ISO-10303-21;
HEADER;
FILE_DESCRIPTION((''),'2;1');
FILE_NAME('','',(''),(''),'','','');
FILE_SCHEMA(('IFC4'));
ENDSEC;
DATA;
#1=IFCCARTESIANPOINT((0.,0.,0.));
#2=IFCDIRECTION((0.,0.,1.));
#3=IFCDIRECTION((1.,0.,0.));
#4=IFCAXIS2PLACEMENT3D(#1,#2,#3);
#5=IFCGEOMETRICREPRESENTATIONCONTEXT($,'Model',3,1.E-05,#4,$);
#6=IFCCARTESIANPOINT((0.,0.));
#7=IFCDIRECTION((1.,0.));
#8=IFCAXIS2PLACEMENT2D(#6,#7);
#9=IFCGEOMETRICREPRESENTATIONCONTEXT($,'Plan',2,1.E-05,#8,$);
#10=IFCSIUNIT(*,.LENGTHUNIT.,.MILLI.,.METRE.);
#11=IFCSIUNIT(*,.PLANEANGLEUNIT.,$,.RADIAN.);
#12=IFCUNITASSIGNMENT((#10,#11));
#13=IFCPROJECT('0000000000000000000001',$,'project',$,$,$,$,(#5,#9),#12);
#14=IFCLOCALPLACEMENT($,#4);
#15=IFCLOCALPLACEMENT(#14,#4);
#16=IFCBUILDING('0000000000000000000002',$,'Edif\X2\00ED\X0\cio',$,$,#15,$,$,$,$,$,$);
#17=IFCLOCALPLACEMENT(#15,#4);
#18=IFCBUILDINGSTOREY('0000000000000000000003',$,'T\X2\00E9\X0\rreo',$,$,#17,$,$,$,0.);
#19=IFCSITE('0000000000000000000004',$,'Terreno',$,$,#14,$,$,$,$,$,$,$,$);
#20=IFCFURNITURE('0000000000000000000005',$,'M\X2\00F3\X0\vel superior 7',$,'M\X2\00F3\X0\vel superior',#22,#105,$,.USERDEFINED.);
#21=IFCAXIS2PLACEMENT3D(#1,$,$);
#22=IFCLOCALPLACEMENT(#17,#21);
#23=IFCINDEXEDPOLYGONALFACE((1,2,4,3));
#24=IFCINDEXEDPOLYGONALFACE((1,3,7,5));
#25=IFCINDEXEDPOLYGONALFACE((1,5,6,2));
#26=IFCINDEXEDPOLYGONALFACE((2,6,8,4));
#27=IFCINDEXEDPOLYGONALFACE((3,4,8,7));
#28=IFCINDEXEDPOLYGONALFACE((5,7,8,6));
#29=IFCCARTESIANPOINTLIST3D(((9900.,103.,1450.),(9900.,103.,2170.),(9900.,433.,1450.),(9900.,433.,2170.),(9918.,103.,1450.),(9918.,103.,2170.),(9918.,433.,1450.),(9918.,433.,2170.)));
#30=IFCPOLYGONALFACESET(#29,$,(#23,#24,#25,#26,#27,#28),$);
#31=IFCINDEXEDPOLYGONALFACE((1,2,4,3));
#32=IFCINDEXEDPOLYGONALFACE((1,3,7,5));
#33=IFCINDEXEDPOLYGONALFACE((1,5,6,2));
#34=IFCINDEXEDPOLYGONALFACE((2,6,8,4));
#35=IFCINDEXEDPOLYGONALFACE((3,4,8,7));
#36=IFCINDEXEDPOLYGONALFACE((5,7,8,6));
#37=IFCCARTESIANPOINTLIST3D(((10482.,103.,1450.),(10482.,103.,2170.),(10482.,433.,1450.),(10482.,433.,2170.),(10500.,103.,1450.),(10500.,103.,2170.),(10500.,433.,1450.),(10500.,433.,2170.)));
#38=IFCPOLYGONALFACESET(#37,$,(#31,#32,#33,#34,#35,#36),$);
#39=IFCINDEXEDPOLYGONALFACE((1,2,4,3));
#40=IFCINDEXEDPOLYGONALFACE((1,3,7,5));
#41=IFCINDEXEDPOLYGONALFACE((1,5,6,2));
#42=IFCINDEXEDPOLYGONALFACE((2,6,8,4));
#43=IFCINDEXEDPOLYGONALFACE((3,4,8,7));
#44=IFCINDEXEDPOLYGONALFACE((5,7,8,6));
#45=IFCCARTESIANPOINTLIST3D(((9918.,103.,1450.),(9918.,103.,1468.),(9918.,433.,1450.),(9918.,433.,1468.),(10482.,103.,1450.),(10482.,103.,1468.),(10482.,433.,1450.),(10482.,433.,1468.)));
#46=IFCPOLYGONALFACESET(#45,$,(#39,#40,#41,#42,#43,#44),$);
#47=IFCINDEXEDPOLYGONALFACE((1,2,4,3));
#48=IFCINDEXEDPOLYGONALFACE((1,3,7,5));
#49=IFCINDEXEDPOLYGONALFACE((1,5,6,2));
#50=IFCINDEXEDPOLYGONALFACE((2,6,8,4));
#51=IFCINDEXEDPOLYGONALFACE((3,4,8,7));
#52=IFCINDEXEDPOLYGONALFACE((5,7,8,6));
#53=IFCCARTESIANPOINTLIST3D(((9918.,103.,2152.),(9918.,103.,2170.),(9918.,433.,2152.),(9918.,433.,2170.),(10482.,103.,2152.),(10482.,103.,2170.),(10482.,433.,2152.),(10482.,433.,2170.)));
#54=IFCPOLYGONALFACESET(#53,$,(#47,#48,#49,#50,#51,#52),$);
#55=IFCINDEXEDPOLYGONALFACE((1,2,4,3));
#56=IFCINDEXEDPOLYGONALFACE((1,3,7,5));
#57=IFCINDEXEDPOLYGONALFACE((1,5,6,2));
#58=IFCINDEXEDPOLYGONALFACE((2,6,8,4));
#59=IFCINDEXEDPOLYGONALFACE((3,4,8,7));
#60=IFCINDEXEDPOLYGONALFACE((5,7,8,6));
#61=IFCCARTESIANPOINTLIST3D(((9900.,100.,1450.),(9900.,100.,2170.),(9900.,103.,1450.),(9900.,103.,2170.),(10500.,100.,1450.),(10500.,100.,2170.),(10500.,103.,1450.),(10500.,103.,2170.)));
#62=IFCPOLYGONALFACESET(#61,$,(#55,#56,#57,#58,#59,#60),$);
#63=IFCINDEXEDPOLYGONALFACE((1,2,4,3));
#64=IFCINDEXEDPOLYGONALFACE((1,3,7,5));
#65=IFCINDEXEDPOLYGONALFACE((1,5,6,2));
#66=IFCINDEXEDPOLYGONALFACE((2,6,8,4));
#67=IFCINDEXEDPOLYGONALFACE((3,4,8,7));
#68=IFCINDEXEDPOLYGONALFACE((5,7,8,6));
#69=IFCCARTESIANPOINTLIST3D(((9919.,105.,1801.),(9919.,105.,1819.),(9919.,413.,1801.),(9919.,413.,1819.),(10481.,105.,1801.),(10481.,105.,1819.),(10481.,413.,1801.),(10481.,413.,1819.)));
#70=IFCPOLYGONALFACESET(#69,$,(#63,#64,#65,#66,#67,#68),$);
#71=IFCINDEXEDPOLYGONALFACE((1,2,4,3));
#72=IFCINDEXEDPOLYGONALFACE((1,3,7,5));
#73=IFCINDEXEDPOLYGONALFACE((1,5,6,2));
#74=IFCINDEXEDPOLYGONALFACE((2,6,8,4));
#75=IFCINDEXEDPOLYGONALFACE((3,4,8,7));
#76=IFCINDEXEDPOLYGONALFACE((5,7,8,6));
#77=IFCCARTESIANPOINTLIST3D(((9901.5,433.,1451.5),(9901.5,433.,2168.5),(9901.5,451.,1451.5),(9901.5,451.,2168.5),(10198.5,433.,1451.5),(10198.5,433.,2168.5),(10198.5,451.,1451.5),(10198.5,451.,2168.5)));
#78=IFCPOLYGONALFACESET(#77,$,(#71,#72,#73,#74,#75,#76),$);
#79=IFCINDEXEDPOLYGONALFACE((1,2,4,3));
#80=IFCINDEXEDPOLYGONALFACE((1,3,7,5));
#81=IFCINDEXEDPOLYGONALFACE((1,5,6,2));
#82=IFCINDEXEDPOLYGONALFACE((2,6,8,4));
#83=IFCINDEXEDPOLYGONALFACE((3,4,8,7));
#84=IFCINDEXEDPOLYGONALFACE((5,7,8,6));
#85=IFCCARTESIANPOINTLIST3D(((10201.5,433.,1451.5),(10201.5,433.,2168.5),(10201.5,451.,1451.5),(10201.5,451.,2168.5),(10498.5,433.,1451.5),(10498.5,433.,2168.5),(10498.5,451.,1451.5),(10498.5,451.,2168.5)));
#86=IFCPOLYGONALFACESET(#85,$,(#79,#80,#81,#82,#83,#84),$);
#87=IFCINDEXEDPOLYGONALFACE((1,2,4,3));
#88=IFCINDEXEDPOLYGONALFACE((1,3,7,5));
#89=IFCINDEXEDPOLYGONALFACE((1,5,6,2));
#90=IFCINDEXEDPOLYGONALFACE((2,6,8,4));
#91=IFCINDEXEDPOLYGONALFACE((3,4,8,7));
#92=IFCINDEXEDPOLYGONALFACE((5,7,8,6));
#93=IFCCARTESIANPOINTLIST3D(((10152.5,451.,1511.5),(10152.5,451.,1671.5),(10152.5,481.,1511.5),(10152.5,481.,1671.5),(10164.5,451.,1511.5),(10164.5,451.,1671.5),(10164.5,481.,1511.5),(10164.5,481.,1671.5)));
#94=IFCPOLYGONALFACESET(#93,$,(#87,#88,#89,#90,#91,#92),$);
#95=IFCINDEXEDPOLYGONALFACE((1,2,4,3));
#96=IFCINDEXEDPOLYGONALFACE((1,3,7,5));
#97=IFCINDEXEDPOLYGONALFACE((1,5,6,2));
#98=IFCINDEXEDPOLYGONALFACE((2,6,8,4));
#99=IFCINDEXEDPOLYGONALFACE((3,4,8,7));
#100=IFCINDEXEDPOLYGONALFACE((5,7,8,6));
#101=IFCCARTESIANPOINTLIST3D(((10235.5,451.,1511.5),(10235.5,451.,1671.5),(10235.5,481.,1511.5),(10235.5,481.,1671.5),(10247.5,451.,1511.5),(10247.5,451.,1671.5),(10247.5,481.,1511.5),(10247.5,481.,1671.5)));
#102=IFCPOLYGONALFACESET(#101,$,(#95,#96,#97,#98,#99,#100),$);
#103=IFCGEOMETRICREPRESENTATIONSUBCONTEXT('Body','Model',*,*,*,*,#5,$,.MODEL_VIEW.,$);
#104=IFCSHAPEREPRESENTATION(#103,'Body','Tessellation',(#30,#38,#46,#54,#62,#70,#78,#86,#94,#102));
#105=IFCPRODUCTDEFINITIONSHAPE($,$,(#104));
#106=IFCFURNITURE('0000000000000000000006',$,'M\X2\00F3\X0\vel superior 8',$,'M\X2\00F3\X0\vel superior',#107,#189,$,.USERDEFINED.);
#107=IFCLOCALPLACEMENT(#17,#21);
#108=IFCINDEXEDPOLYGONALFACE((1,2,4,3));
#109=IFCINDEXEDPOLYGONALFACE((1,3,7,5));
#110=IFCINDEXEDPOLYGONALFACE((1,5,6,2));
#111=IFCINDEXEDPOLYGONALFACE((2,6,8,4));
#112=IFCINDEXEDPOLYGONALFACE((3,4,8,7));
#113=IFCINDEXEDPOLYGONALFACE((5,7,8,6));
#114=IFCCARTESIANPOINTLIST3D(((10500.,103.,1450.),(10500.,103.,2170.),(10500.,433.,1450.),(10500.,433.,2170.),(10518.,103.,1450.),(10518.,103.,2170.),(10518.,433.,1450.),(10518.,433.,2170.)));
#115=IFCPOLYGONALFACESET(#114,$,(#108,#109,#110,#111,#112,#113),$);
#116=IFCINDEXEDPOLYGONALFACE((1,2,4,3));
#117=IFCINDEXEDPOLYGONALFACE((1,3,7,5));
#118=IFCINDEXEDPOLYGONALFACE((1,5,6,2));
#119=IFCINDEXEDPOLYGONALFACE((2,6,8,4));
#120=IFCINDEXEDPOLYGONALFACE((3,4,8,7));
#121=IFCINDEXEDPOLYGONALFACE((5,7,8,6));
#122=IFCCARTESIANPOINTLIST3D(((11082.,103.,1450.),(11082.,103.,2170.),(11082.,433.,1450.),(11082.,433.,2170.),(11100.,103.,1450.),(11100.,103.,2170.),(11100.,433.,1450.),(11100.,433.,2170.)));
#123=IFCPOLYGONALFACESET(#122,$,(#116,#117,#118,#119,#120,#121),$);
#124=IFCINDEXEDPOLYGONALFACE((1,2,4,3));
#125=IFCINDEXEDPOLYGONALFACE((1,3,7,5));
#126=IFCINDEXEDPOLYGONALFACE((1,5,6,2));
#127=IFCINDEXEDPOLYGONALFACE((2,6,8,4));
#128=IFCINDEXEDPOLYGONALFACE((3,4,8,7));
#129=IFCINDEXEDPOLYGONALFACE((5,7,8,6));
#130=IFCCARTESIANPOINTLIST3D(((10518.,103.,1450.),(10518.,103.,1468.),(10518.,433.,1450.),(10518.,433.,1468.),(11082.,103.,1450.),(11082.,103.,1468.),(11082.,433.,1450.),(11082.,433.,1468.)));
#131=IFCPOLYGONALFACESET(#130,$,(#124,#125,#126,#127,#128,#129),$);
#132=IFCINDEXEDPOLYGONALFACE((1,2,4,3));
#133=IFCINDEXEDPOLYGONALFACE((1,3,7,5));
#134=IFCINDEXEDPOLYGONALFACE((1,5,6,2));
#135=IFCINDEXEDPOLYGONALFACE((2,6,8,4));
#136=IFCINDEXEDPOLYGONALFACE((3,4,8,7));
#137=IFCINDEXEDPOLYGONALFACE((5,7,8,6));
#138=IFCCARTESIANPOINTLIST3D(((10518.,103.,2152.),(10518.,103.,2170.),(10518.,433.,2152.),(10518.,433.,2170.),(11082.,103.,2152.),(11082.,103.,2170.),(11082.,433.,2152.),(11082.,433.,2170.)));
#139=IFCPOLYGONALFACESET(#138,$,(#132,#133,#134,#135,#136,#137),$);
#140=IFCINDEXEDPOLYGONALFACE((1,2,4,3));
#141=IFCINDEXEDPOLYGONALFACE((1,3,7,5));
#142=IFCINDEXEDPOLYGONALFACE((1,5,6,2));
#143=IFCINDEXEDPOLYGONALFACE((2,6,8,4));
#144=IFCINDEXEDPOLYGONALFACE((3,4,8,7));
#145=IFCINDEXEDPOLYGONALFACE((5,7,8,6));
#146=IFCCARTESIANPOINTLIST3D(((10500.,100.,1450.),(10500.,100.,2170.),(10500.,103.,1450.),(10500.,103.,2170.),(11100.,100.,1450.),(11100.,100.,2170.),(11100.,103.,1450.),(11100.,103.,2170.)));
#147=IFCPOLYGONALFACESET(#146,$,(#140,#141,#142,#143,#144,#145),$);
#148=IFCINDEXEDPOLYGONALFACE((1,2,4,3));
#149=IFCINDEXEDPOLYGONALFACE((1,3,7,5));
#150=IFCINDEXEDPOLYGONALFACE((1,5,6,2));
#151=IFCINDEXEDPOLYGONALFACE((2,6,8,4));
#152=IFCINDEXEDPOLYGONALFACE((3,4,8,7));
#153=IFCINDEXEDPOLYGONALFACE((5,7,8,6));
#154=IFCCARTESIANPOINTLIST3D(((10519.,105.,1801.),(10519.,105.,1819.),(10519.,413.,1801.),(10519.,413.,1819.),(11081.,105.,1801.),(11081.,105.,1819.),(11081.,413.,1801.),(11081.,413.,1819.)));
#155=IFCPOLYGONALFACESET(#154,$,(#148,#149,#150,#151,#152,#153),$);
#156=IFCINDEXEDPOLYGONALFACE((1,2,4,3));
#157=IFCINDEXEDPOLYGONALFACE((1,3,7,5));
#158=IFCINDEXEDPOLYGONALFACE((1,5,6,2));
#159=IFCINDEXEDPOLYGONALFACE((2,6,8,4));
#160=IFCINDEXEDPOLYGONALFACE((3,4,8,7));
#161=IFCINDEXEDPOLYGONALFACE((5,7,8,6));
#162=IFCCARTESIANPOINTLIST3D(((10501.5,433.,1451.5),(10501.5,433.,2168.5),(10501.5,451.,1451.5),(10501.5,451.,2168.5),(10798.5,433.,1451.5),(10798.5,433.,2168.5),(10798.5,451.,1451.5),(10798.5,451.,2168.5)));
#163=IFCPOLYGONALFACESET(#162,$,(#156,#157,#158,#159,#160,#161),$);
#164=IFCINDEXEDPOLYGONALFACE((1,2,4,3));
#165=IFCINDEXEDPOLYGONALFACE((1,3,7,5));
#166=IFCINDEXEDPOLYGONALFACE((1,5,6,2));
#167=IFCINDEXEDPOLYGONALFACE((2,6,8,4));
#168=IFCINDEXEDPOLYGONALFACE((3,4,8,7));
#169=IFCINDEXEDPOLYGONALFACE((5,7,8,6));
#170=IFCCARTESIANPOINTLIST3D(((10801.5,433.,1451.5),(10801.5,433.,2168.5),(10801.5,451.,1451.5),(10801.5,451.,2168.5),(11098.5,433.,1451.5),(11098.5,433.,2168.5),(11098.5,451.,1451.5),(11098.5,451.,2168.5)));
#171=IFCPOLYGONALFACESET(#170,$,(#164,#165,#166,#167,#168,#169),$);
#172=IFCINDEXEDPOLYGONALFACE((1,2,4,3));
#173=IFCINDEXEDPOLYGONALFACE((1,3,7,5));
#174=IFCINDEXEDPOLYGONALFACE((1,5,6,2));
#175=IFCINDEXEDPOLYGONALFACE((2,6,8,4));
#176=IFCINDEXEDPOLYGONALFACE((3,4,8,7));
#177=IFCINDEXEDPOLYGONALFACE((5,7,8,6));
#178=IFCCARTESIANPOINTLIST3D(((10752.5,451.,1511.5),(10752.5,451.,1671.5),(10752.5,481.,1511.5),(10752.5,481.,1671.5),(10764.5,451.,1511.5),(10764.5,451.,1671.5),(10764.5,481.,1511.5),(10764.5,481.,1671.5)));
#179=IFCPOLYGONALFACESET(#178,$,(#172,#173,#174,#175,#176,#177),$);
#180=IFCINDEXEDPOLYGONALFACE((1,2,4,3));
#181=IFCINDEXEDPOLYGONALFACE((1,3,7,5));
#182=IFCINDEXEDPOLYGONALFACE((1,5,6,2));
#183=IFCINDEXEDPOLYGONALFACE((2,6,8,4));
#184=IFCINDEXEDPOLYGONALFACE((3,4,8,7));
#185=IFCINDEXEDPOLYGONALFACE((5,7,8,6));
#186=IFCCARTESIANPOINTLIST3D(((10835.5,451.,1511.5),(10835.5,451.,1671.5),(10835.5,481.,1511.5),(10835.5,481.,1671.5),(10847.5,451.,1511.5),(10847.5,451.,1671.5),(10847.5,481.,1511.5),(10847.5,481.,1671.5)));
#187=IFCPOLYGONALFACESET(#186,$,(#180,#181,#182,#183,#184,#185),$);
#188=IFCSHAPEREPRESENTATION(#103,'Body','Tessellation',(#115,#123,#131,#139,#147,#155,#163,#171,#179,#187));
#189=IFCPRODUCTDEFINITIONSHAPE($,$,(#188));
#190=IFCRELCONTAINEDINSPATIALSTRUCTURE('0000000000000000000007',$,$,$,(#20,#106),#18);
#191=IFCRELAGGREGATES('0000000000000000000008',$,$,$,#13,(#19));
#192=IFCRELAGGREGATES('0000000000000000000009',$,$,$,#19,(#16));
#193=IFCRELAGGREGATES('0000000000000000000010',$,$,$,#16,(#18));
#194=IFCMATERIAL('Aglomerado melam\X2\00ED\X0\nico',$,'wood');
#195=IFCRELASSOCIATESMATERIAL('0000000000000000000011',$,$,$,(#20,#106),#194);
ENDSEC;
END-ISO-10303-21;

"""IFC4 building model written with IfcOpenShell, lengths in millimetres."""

from ifc_helpers import new_model, si_unit, frame, frame_2d, origin_with_axes, origin_2d_with_axis, place, context, subcontext, project, spatial, rectangle, extrude, material, element, save


model = new_model("IFC4")

# Units and contexts
model_context = context("Model", 3, precision=1e-05, world=origin_with_axes())
plan_context = context("Plan", 2, precision=1e-05, world=origin_2d_with_axis())
body_context = subcontext(model_context, "Body", "Model", "MODEL_VIEW")
ifc_project = project(units=[si_unit("LENGTHUNIT", "METRE", prefix="MILLI"), si_unit("PLANEANGLEUNIT", "RADIAN")], contexts=[model_context, plan_context])

# Site, building, storey
site_placement = place(None, origin_with_axes())
site = spatial("IfcSite", under=ifc_project, at=site_placement, Name="Terreno")
building_placement = place(site_placement, origin_with_axes())
building = spatial("IfcBuilding", under=site, at=building_placement, Name="Edifício")
storey_placement = place(building_placement, origin_with_axes())
storey = spatial("IfcBuildingStorey", under=building, at=storey_placement, Name="Térreo", Elevation=0.0)

# Furniture
ifc_material_1 = material(Name="Aglomerado melamínico", Category="wood")
for number, where, z_axis, x_axis, name in (
    (1, (9900.0, 100.0, 0.0), (0.0, 0.0, 1.0), (1.0, 0.0, 0.0), "Móvel superior 7"),
    (2, (10500.0, 100.0, 0.0), (0.0, 0.0, 1.0), (1.0, 0.0, 0.0), "Móvel superior 8"),
):
    element("IfcFurniture", number, at=place(storey_placement, frame(where, z_axis=z_axis, x_axis=x_axis)), inside=storey, material=ifc_material_1, Name=name, ObjectType="Móvel superior", PredefinedType="USERDEFINED", context=body_context, shape_type="SweptSolid", body=[
        extrude(rectangle(XDim=18.0, YDim=330.0, at=frame_2d((9.0, 168.0))), frame((0.0, 0.0, 1450.0)), (0.0, 0.0, 1.0), 720.0),
        extrude(rectangle(XDim=18.0, YDim=330.0, at=frame_2d((591.0, 168.0))), frame((0.0, 0.0, 1450.0)), (0.0, 0.0, 1.0), 720.0),
        extrude(rectangle(XDim=564.0, YDim=330.0, at=frame_2d((300.0, 168.0))), frame((0.0, 0.0, 1450.0)), (0.0, 0.0, 1.0), 18.0),
        extrude(rectangle(XDim=564.0, YDim=330.0, at=frame_2d((300.0, 168.0))), frame((0.0, 0.0, 2152.0)), (0.0, 0.0, 1.0), 18.0),
        extrude(rectangle(XDim=600.0, YDim=3.0, at=frame_2d((300.0, 1.5))), frame((0.0, 0.0, 1450.0)), (0.0, 0.0, 1.0), 720.0),
        extrude(rectangle(XDim=562.0, YDim=308.0, at=frame_2d((300.0, 159.0))), frame((0.0, 0.0, 1801.0)), (0.0, 0.0, 1.0), 18.0),
        extrude(rectangle(XDim=297.0, YDim=18.0, at=frame_2d((150.0, 342.0))), frame((0.0, 0.0, 1451.5)), (0.0, 0.0, 1.0), 717.0),
        extrude(rectangle(XDim=297.0, YDim=18.0, at=frame_2d((450.0, 342.0))), frame((0.0, 0.0, 1451.5)), (0.0, 0.0, 1.0), 717.0),
        extrude(rectangle(XDim=12.0, YDim=30.0, at=frame_2d((258.5, 366.0))), frame((0.0, 0.0, 1511.5)), (0.0, 0.0, 1.0), 160.0),
        extrude(rectangle(XDim=12.0, YDim=30.0, at=frame_2d((341.5, 366.0))), frame((0.0, 0.0, 1511.5)), (0.0, 0.0, 1.0), 160.0),
    ])

save(model, "model.ifc")
